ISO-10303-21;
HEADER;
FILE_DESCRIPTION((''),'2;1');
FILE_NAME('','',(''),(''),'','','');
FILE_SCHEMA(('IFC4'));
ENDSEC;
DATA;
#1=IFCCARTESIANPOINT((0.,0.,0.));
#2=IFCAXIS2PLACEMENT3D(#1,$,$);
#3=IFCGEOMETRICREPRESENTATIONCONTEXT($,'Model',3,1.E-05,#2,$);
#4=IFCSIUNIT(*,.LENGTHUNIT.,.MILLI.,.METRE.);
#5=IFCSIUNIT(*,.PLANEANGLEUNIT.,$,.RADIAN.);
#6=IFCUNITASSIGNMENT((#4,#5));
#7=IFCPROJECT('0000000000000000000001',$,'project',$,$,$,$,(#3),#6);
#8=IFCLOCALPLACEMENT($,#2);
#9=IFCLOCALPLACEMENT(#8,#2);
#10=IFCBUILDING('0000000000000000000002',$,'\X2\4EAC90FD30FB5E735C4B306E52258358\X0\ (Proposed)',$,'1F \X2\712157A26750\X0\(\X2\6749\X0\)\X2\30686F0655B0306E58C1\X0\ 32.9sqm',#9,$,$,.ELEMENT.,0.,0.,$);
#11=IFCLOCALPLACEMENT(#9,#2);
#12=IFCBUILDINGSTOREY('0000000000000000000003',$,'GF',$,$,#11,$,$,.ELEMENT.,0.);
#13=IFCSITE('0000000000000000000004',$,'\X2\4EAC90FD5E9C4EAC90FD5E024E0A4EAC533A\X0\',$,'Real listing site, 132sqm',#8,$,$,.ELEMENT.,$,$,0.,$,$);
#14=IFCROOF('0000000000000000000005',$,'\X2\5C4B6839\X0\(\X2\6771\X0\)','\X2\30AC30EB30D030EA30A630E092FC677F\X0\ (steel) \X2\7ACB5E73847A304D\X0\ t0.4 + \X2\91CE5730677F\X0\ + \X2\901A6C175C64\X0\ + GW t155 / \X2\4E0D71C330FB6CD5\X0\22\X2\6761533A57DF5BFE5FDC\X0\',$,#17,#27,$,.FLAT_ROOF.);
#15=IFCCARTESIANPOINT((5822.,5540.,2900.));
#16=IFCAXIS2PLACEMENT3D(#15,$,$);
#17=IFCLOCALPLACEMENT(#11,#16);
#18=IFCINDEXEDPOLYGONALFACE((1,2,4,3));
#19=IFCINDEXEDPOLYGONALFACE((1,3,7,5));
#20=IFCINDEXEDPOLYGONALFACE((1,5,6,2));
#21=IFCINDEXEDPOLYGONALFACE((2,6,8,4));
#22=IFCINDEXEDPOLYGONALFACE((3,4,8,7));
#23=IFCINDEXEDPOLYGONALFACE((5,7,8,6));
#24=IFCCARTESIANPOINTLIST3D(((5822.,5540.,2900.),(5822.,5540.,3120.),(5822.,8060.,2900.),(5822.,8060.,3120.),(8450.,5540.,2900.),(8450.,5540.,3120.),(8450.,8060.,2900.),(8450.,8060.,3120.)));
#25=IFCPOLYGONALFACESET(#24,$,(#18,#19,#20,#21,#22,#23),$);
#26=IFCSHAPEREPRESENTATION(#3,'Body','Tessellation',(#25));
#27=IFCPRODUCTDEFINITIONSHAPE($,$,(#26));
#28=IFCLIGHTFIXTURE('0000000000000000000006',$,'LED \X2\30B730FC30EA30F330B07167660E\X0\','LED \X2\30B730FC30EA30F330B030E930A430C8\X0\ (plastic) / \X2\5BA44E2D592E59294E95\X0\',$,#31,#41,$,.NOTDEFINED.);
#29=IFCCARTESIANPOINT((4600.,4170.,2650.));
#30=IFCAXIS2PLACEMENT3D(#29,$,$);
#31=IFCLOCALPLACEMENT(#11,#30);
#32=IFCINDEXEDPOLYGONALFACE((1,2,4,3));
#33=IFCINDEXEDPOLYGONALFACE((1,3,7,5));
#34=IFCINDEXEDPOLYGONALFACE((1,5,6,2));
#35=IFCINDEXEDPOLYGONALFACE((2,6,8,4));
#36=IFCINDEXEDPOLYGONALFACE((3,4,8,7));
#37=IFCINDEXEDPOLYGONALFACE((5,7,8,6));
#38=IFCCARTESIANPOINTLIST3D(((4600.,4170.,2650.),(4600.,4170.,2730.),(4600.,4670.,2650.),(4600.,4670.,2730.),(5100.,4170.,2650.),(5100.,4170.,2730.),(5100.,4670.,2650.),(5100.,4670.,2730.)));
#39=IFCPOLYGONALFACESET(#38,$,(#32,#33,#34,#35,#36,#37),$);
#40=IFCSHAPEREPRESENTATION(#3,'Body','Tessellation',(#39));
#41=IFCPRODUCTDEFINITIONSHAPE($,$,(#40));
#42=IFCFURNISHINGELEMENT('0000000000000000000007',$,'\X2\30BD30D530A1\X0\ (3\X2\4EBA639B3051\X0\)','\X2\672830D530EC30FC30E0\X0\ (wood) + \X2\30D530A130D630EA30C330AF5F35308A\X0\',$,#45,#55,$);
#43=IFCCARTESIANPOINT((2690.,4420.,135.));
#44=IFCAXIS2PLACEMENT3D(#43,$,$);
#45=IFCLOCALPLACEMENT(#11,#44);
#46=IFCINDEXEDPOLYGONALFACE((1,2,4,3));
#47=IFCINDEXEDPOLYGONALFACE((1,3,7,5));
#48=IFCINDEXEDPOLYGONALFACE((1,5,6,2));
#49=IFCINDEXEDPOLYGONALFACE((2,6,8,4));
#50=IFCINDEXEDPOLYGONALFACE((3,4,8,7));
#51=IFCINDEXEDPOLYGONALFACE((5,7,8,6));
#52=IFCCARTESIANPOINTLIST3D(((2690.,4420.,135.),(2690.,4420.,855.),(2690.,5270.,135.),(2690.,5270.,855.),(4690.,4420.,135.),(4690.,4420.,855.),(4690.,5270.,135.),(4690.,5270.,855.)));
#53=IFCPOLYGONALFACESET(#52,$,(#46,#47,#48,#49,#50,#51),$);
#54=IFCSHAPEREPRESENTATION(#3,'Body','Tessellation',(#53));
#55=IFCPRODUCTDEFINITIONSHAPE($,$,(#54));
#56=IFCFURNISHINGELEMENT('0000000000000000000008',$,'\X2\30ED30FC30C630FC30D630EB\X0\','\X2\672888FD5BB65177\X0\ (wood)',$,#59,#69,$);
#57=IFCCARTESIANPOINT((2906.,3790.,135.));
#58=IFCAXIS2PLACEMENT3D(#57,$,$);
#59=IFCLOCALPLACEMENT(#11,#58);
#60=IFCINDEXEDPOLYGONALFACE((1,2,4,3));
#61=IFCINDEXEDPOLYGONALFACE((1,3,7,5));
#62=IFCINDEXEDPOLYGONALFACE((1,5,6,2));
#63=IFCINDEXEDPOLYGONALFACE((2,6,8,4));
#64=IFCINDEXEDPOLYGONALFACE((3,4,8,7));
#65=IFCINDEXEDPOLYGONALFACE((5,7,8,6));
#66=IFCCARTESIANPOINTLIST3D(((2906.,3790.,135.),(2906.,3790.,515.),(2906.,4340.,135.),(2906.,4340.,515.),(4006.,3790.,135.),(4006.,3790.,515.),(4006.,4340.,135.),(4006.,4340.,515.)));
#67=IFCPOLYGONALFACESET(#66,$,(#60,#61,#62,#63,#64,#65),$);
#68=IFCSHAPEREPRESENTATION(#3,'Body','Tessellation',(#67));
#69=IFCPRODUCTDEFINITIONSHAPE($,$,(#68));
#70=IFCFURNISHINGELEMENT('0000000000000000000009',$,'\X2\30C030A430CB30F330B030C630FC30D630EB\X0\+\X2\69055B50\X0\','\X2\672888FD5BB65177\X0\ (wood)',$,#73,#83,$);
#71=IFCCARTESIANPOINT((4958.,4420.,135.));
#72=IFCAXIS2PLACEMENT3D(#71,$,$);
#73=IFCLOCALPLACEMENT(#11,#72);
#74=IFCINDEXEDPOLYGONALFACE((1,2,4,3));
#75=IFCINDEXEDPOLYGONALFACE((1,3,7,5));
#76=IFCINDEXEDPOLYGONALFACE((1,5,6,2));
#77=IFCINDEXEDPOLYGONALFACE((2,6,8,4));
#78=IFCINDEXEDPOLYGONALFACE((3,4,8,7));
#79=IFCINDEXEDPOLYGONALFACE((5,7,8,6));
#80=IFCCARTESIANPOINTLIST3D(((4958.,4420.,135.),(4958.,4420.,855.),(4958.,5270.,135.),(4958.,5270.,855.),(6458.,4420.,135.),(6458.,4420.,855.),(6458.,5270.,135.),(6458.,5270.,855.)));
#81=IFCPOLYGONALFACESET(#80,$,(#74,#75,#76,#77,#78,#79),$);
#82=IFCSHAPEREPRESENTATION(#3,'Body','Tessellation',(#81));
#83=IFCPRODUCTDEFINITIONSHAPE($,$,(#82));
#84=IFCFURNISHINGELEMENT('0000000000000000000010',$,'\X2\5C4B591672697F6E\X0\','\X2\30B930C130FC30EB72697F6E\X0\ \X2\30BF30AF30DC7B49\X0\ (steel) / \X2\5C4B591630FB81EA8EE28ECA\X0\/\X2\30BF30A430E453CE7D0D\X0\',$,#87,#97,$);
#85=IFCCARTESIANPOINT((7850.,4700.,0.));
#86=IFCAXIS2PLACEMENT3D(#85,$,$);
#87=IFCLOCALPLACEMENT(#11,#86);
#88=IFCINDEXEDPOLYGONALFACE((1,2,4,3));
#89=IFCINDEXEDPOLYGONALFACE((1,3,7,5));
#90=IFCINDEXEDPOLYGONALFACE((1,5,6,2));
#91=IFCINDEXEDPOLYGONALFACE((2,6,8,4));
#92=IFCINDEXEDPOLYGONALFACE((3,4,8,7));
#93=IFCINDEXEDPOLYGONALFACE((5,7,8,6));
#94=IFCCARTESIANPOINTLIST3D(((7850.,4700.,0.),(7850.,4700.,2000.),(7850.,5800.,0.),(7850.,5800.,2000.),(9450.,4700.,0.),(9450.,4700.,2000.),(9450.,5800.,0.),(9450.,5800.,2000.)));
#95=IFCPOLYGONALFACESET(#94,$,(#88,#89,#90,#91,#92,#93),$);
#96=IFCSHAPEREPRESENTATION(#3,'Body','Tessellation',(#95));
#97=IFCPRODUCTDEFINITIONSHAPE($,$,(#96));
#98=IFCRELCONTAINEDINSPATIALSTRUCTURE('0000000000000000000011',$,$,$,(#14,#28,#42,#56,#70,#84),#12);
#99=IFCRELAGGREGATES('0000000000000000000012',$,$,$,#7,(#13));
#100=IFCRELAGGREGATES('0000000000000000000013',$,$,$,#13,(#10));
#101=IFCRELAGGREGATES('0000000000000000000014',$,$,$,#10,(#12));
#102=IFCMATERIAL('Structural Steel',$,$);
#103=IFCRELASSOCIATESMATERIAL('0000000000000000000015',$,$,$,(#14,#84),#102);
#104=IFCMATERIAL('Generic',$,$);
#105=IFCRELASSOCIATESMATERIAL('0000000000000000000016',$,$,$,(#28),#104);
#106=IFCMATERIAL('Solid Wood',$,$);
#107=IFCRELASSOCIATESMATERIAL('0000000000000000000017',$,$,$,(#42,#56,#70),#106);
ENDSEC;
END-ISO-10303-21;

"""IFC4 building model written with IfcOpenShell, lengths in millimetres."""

from ifc_helpers import new_model, si_unit, frame, frame_2d, origin, place, context, project, spatial, rectangle, extrude, material, element, save


model = new_model("IFC4")

# Units and contexts
model_context = context("Model", 3, precision=1e-05, world=origin())
ifc_project = project(units=[si_unit("LENGTHUNIT", "METRE", prefix="MILLI"), si_unit("PLANEANGLEUNIT", "RADIAN")], contexts=[model_context])

# Site, building, storey
site_placement = place(None, origin())
site = spatial("IfcSite", under=ifc_project, at=site_placement, Name="京都府京都市上京区", ObjectType="Real listing site, 132sqm", CompositionType="ELEMENT", RefElevation=0.0)
building_placement = place(site_placement, origin())
building = spatial("IfcBuilding", under=site, at=building_placement, Name="京都・平屋の別荘 (Proposed)", ObjectType="1F 無垢材(杉)と漆喰の壁 32.9sqm", CompositionType="ELEMENT", ElevationOfRefHeight=0.0, ElevationOfTerrain=0.0)
storey_placement = place(building_placement, origin())
storey = spatial("IfcBuildingStorey", under=building, at=storey_placement, Name="GF", CompositionType="ELEMENT", Elevation=0.0)

# Shared definitions
ifc_material_1 = material(Name="Solid Wood")

# Roof
ifc_material_2 = material(Name="Structural Steel")
roof_1_placement = place(storey_placement, frame((5822.0, 5540.0, 2900.0)))
element("IfcRoof", 1, at=roof_1_placement, inside=storey, material=ifc_material_2, Name="屋根(東)", Description="ガルバリウム鋼板 (steel) 立平葺き t0.4 + 野地板 + 通気層 + GW t155 / 不燃・法22条区域対応", PredefinedType="FLAT_ROOF", context=model_context, shape_type="SweptSolid", body=[
    extrude(rectangle(XDim=2628.0, YDim=2520.0, at=frame_2d((1314.0, 1260.0))), frame((5822.0, 5540.0, 2900.0)), (0.0, 0.0, 1.0), 220.0),
])

# Light fixture
ifc_material_3 = material(Name="Generic")
light_fixture_placement = place(storey_placement, frame((4600.0, 4170.0, 2650.0)))
element("IfcLightFixture", 2, at=light_fixture_placement, inside=storey, material=ifc_material_3, Name="LED シーリング照明", Description="LED シーリングライト (plastic) / 室中央天井", PredefinedType="NOTDEFINED", context=model_context, shape_type="SweptSolid", body=[
    extrude(rectangle(XDim=500.0, YDim=500.0, at=frame_2d((250.0, 250.0))), frame((4600.0, 4170.0, 2650.0)), (0.0, 0.0, 1.0), 80.0),
])

# Furnishing elements
furnishing_1_placement = place(storey_placement, frame((2690.0, 4420.0, 135.0)))
element("IfcFurnishingElement", 3, at=furnishing_1_placement, inside=storey, material=ifc_material_1, Name="ソファ (3人掛け)", Description="木フレーム (wood) + ファブリック張り", context=model_context, shape_type="SweptSolid", body=[
    extrude(rectangle(XDim=2000.0, YDim=850.0, at=frame_2d((1000.0, 425.0))), frame((2690.0, 4420.0, 135.0)), (0.0, 0.0, 1.0), 720.0),
])
furnishing_2_placement = place(storey_placement, frame((2906.0, 3790.0, 135.0)))
element("IfcFurnishingElement", 4, at=furnishing_2_placement, inside=storey, material=ifc_material_1, Name="ローテーブル", Description="木製家具 (wood)", context=model_context, shape_type="SweptSolid", body=[
    extrude(rectangle(XDim=1100.0, YDim=550.0, at=frame_2d((550.0, 275.0))), frame((2906.0, 3790.0, 135.0)), (0.0, 0.0, 1.0), 380.0),
])
furnishing_3_placement = place(storey_placement, frame((4958.0, 4420.0, 135.0)))
element("IfcFurnishingElement", 5, at=furnishing_3_placement, inside=storey, material=ifc_material_1, Name="ダイニングテーブル+椅子", Description="木製家具 (wood)", context=model_context, shape_type="SweptSolid", body=[
    extrude(rectangle(XDim=1500.0, YDim=850.0, at=frame_2d((750.0, 425.0))), frame((4958.0, 4420.0, 135.0)), (0.0, 0.0, 1.0), 720.0),
])
furnishing_4_placement = place(storey_placement, frame((7850.0, 4700.0, 0.0)))
element("IfcFurnishingElement", 6, at=furnishing_4_placement, inside=storey, material=ifc_material_2, Name="屋外物置", Description="スチール物置 タクボ等 (steel) / 屋外・自転車/タイヤ収納", context=model_context, shape_type="SweptSolid", body=[
    extrude(rectangle(XDim=1600.0, YDim=1100.0, at=frame_2d((800.0, 550.0))), frame((7850.0, 4700.0, 0.0)), (0.0, 0.0, 1.0), 2000.0),
])

save(model, "model.ifc")
